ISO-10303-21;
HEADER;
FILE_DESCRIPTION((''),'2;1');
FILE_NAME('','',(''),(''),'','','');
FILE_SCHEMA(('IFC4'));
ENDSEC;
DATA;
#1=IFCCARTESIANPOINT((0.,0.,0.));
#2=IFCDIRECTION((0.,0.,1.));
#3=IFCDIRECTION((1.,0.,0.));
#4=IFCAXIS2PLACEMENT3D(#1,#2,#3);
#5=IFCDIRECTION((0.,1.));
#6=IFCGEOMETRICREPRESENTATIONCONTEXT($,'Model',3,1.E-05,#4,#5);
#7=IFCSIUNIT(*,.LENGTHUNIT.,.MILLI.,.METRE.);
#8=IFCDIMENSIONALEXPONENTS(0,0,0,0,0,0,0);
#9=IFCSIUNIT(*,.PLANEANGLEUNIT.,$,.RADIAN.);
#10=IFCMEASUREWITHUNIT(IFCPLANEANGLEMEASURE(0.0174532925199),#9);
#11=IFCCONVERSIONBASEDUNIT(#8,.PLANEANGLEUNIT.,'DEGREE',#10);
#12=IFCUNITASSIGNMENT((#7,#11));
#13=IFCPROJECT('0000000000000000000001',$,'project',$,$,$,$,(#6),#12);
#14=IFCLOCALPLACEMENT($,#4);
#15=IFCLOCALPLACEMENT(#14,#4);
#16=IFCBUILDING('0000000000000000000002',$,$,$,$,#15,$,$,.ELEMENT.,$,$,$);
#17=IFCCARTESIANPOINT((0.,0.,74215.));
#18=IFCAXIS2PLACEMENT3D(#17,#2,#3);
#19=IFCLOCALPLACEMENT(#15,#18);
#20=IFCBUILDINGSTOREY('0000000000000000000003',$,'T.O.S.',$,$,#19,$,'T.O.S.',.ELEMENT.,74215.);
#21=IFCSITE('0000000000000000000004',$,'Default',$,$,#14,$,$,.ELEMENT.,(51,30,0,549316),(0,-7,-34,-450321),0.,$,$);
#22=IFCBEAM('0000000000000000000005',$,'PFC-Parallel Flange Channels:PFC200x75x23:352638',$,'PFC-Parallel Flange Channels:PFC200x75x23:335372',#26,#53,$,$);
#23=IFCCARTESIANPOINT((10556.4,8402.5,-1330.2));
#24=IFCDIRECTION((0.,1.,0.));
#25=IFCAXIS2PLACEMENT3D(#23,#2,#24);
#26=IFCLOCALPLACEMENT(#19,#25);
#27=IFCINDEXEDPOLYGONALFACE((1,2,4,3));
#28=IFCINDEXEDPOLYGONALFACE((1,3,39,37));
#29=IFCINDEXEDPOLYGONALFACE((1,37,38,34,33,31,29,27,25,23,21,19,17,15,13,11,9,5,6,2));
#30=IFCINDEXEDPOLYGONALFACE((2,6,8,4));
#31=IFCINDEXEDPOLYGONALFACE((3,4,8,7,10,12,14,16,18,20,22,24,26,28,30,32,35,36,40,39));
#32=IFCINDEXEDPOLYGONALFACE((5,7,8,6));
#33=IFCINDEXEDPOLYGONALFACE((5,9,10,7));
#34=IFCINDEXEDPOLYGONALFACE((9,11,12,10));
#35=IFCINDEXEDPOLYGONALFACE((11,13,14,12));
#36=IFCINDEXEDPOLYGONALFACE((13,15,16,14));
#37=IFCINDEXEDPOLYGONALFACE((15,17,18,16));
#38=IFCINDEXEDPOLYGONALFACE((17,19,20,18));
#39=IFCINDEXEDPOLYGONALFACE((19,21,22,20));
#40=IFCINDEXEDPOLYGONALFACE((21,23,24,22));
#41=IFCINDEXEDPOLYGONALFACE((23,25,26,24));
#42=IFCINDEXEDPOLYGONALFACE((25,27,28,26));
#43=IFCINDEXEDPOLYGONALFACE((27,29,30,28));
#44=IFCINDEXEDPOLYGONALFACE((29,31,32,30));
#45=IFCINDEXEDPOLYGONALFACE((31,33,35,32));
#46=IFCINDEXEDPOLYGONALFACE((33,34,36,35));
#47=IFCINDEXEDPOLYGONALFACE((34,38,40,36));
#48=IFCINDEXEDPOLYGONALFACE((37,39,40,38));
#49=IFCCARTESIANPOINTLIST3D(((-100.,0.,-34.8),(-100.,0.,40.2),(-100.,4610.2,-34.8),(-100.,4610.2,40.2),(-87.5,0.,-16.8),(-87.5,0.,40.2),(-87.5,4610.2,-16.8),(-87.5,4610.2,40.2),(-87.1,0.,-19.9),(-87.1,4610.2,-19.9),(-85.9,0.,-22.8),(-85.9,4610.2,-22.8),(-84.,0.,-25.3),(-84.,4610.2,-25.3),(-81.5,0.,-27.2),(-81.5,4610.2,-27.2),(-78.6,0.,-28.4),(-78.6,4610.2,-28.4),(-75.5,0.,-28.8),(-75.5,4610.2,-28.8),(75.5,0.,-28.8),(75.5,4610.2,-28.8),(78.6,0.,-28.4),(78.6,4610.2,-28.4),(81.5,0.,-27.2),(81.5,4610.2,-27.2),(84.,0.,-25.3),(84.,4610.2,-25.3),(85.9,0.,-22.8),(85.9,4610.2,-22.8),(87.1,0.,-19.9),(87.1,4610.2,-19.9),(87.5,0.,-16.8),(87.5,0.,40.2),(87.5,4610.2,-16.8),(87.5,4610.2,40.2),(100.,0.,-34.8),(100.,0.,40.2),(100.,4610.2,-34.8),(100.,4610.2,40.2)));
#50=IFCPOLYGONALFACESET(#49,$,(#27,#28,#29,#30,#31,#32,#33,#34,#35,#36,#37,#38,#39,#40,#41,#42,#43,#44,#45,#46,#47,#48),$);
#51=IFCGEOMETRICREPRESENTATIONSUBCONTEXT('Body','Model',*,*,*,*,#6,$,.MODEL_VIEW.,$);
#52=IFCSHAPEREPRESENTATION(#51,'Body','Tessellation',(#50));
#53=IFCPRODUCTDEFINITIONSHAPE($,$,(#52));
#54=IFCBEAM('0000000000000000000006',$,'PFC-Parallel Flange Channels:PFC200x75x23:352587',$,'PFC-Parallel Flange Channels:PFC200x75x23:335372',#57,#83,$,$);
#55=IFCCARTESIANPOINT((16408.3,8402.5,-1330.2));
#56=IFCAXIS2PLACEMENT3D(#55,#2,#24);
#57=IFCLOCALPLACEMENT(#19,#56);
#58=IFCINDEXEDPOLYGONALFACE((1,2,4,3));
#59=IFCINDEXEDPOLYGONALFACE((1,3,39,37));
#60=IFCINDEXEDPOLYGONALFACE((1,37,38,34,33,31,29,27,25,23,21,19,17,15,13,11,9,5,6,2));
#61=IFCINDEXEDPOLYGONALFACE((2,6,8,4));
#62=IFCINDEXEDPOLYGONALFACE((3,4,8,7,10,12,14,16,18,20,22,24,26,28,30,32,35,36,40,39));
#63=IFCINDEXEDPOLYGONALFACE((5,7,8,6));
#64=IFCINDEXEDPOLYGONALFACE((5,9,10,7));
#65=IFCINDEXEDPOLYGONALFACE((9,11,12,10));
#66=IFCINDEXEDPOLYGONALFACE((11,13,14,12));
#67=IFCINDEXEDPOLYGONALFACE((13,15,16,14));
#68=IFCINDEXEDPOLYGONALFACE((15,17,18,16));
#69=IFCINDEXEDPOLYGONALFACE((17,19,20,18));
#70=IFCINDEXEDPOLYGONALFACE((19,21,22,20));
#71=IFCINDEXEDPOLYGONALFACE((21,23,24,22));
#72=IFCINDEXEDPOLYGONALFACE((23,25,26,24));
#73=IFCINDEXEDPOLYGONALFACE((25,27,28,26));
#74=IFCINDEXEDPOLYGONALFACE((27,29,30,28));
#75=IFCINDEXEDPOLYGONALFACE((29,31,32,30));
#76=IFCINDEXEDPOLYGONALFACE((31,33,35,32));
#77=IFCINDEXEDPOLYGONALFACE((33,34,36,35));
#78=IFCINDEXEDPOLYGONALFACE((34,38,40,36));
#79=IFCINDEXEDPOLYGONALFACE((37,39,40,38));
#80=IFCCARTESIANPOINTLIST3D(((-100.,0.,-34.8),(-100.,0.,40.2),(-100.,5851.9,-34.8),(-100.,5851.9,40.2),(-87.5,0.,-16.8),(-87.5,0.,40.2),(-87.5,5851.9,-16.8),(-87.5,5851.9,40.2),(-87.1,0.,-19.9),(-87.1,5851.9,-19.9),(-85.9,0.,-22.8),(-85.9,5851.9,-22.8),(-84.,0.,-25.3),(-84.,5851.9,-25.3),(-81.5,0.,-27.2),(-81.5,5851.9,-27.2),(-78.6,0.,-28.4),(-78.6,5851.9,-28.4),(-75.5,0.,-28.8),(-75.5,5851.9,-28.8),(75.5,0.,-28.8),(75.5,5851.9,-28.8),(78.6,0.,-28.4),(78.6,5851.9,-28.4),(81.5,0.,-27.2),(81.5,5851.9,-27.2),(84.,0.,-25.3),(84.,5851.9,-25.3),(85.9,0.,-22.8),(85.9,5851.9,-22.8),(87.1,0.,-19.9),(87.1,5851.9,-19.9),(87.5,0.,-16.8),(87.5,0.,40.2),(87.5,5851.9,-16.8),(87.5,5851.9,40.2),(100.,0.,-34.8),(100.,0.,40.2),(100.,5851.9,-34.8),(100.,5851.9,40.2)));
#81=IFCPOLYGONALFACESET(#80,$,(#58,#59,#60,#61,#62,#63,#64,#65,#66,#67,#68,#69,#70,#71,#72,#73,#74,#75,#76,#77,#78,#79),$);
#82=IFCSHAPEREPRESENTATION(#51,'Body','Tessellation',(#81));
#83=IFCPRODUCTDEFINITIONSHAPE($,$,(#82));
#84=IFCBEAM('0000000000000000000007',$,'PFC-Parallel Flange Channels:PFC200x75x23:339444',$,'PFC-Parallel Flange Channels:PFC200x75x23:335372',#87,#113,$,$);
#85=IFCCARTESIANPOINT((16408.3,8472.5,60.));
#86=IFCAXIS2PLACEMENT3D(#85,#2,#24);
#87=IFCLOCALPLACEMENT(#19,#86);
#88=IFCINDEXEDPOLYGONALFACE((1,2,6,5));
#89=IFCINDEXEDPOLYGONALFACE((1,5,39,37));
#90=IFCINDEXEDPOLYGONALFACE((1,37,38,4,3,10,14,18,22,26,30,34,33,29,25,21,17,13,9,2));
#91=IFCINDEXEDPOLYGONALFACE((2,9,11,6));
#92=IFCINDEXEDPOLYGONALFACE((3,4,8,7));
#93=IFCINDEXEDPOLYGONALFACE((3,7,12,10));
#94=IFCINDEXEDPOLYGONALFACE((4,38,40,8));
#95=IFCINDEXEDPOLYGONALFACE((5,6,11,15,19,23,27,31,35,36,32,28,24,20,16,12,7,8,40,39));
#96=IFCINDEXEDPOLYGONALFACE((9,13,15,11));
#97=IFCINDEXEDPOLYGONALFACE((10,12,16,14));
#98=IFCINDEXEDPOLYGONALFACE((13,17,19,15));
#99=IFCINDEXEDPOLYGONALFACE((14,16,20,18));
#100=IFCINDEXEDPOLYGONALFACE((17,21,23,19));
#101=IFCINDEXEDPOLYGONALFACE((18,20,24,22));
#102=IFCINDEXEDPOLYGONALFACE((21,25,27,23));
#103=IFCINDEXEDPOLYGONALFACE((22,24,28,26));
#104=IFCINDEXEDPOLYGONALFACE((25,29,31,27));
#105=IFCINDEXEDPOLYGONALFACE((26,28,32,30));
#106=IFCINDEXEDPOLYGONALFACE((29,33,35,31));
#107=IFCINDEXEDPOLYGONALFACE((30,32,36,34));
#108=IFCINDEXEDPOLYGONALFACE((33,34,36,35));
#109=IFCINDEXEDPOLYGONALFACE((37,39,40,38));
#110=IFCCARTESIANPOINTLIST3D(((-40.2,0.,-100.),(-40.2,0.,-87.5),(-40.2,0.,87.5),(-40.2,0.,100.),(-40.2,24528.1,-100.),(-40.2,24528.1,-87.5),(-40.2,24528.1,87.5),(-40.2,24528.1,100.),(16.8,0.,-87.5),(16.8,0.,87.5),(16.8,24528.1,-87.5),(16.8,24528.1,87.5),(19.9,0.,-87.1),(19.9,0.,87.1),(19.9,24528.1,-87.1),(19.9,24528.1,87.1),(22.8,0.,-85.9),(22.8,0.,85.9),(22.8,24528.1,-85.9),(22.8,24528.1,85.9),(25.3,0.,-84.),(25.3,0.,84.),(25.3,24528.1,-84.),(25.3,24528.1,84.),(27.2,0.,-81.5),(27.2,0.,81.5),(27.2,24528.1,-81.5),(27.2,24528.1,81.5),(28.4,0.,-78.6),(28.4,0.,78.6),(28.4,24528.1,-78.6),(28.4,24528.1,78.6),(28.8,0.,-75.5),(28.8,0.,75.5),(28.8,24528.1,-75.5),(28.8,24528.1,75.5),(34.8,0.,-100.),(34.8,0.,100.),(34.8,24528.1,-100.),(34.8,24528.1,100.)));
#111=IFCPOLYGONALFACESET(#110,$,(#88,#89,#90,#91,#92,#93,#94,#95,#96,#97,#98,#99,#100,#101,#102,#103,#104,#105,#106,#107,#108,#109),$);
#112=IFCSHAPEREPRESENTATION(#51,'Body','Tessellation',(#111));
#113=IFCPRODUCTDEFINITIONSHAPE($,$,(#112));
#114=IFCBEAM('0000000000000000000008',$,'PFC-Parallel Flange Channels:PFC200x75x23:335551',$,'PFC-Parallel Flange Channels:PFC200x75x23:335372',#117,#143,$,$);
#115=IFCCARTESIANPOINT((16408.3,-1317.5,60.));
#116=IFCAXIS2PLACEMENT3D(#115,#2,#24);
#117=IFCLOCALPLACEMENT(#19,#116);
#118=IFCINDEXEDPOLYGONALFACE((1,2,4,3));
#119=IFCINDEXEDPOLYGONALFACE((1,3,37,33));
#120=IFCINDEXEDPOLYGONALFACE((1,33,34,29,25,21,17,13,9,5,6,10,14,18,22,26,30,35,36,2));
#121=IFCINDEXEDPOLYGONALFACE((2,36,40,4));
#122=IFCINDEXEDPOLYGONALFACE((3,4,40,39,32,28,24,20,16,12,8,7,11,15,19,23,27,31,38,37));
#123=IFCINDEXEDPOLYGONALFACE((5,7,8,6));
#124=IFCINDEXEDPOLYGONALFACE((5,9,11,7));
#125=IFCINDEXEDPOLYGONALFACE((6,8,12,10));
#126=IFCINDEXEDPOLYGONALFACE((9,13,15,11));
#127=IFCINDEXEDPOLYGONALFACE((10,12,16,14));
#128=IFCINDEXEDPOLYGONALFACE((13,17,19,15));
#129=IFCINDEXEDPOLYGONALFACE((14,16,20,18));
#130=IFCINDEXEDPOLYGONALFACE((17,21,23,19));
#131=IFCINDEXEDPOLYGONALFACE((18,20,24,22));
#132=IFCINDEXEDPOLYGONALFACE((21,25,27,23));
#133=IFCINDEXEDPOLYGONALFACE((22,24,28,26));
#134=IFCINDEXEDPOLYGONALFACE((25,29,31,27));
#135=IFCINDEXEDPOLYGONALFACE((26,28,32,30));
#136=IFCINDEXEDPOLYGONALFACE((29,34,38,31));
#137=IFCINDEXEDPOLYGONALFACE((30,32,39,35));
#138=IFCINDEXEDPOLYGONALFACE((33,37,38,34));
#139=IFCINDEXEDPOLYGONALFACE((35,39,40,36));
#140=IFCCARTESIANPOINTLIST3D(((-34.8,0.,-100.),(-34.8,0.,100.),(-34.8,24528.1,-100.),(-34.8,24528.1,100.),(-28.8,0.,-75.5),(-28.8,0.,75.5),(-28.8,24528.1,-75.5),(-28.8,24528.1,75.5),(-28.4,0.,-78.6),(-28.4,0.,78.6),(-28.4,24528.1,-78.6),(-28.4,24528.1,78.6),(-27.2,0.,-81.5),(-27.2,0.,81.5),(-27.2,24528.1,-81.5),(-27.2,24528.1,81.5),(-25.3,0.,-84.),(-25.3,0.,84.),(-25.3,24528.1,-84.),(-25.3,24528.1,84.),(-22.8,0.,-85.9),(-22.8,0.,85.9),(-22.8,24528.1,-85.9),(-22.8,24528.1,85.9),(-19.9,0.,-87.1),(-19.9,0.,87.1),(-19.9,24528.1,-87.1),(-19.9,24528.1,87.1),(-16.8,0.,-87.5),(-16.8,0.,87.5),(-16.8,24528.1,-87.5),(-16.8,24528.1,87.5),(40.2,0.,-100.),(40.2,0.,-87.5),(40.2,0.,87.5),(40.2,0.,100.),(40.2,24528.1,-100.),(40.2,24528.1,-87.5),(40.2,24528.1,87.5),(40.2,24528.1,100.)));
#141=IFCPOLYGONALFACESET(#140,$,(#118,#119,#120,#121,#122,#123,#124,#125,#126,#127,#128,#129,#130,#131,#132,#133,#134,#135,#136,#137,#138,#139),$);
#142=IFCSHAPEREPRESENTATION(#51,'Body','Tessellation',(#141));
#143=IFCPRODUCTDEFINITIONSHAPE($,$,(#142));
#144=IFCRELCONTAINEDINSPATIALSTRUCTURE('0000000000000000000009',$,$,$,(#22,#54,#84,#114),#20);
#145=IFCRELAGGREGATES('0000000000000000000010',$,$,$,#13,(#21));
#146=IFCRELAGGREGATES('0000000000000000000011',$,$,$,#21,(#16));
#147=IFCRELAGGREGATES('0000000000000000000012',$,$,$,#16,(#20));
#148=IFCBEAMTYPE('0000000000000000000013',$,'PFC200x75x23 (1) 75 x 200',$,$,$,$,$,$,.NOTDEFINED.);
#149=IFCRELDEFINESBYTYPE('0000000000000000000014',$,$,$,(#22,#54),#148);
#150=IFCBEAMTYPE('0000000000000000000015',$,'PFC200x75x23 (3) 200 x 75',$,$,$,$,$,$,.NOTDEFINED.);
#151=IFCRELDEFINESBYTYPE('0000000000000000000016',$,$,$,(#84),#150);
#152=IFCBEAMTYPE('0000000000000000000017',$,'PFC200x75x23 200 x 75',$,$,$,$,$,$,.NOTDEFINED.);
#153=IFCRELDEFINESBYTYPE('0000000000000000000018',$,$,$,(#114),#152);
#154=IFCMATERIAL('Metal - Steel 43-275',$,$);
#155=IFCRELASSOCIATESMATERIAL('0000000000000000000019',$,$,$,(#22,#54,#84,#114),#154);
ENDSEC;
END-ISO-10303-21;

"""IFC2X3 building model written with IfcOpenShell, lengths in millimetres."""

from ifc_helpers import new_model, entity, si_unit, converted_unit, point, direction, frame, frame_2d, origin_with_axes, place, context, subcontext, project, spatial, polyline, circle_curve, parameter, trimmed, segment, composite_curve, outline, extrude, material, type_object, element, save


model = new_model("IFC2X3")

# Units and contexts
model_context = context("Model", 3, precision=1e-05, world=origin_with_axes(), true_north=direction((0.0, 1.0)))
body_context = subcontext(model_context, "Body", "Model", "MODEL_VIEW")
ifc_project = project(units=[si_unit("LENGTHUNIT", "METRE", prefix="MILLI"), converted_unit("PLANEANGLEUNIT", "DEGREE", entity("IfcPlaneAngleMeasure", 0.0174532925199), si_unit("PLANEANGLEUNIT", "RADIAN"), dimensions=[0, 0, 0, 0, 0, 0, 0])], contexts=[model_context])

# Site, building, storey
site_placement = place(None, origin_with_axes())
site = spatial("IfcSite", under=ifc_project, at=site_placement, Name="Default", CompositionType="ELEMENT", RefLatitude=(51, 30, 0, 549316), RefLongitude=(0, -7, -34, -450321), RefElevation=0.0)
building_placement = place(site_placement, origin_with_axes())
building = spatial("IfcBuilding", under=site, at=building_placement, CompositionType="ELEMENT")
storey_placement = place(building_placement, frame((0.0, 0.0, 74215.0), z_axis=(0.0, 0.0, 1.0), x_axis=(1.0, 0.0, 0.0)))
storey = spatial("IfcBuildingStorey", under=building, at=storey_placement, Name="T.O.S.", LongName="T.O.S.", CompositionType="ELEMENT", Elevation=74215.0)

# Beams
ifc_material = material(Name="Metal - Steel 43-275")
beam_type_1 = type_object("IfcBeamType", Name="PFC200x75x23 (1) 75 x 200", PredefinedType="NOTDEFINED")
beam_1_placement = place(storey_placement, frame((10556.4, 8402.5, -1330.2), z_axis=(0.0, 0.0, 1.0), x_axis=(0.0, 1.0, 0.0)))
element("IfcBeam", 1, at=beam_1_placement, inside=storey, type_object=beam_type_1, material=ifc_material, Name="PFC-Parallel Flange Channels:PFC200x75x23:352638", ObjectType="PFC-Parallel Flange Channels:PFC200x75x23:335372", context=body_context, shape_type="SweptSolid", body=[
    extrude(outline(composite_curve([segment(polyline([(-40.2, -100.0), (34.8, -100.0), (34.8, 100.0), (-40.2, 100.0), (-40.2, 87.5), (16.8, 87.5)]), True, "CONTINUOUS"), segment(trimmed(circle_curve(frame_2d((16.8, 75.5), x_axis=(1.0, 0.0)), 12.0), [point((16.8, 87.5)), parameter(90.0)], [point((28.8, 75.5)), parameter(0.0)], False, "CARTESIAN"), True, "CONTINUOUS"), segment(polyline([(28.8, 75.5), (28.8, -75.5)]), True, "CONTINUOUS"), segment(trimmed(circle_curve(frame_2d((16.8, -75.5), x_axis=(0.0, -1.0)), 12.0), [point((28.8, -75.5)), parameter(90.0)], [point((16.8, -87.5)), parameter(0.0)], False, "CARTESIAN"), True, "CONTINUOUS"), segment(polyline([(16.8, -87.5), (-40.2, -87.5), (-40.2, -100.0)]), True, "CONTINUOUS")], self_intersect=False)), frame((0.0, 4610.2, 0.0), z_axis=(0.0, -1.0, 0.0), x_axis=(0.0, 0.0, -1.0)), (0.0, 0.0, 1.0), 4610.2),
])
beam_2_placement = place(storey_placement, frame((16408.3, 8402.5, -1330.2), z_axis=(0.0, 0.0, 1.0), x_axis=(0.0, 1.0, 0.0)))
element("IfcBeam", 2, at=beam_2_placement, inside=storey, type_object=beam_type_1, material=ifc_material, Name="PFC-Parallel Flange Channels:PFC200x75x23:352587", ObjectType="PFC-Parallel Flange Channels:PFC200x75x23:335372", context=body_context, shape_type="SweptSolid", body=[
    extrude(outline(composite_curve([segment(polyline([(-40.2, -100.0), (34.8, -100.0), (34.8, 100.0), (-40.2, 100.0), (-40.2, 87.5), (16.8, 87.5)]), True, "CONTINUOUS"), segment(trimmed(circle_curve(frame_2d((16.8, 75.5), x_axis=(1.0, 0.0)), 12.0), [point((16.8, 87.5)), parameter(90.0)], [point((28.8, 75.5)), parameter(0.0)], False, "CARTESIAN"), True, "CONTINUOUS"), segment(polyline([(28.8, 75.5), (28.8, -75.5)]), True, "CONTINUOUS"), segment(trimmed(circle_curve(frame_2d((16.8, -75.5), x_axis=(0.0, -1.0)), 12.0), [point((28.8, -75.5)), parameter(90.0)], [point((16.8, -87.5)), parameter(0.0)], False, "CARTESIAN"), True, "CONTINUOUS"), segment(polyline([(16.8, -87.5), (-40.2, -87.5), (-40.2, -100.0)]), True, "CONTINUOUS")], self_intersect=False)), frame((0.0, 5851.9, 0.0), z_axis=(0.0, -1.0, 0.0), x_axis=(0.0, 0.0, -1.0)), (0.0, 0.0, 1.0), 5851.9),
])
beam_type_2 = type_object("IfcBeamType", Name="PFC200x75x23 (3) 200 x 75", PredefinedType="NOTDEFINED")
beam_3_placement = place(storey_placement, frame((16408.3, 8472.5, 60.0), z_axis=(0.0, 0.0, 1.0), x_axis=(0.0, 1.0, 0.0)))
element("IfcBeam", 3, at=beam_3_placement, inside=storey, type_object=beam_type_2, material=ifc_material, Name="PFC-Parallel Flange Channels:PFC200x75x23:339444", ObjectType="PFC-Parallel Flange Channels:PFC200x75x23:335372", context=body_context, shape_type="SweptSolid", body=[
    extrude(outline(composite_curve([segment(polyline([(-100.0, -40.2), (-87.5, -40.2), (-87.5, 16.8)]), True, "CONTINUOUS"), segment(trimmed(circle_curve(frame_2d((-75.5, 16.8), x_axis=(0.0, 1.0)), 12.0), [point((-87.5, 16.8)), parameter(90.0)], [point((-75.5, 28.8)), parameter(0.0)], False, "CARTESIAN"), True, "CONTINUOUS"), segment(polyline([(-75.5, 28.8), (75.5, 28.8)]), True, "CONTINUOUS"), segment(trimmed(circle_curve(frame_2d((75.5, 16.8), x_axis=(1.0, 0.0)), 12.0), [point((75.5, 28.8)), parameter(90.0)], [point((87.5, 16.8)), parameter(0.0)], False, "CARTESIAN"), True, "CONTINUOUS"), segment(polyline([(87.5, 16.8), (87.5, -40.2), (100.0, -40.2), (100.0, 34.8), (-100.0, 34.8), (-100.0, -40.2)]), True, "CONTINUOUS")], self_intersect=False)), frame((0.0, 24528.1, 0.0), z_axis=(0.0, -1.0, 0.0), x_axis=(0.0, 0.0, -1.0)), (0.0, 0.0, 1.0), 24528.1),
])
beam_type_3 = type_object("IfcBeamType", Name="PFC200x75x23 200 x 75", PredefinedType="NOTDEFINED")
beam_4_placement = place(storey_placement, frame((16408.3, -1317.5, 60.0), z_axis=(0.0, 0.0, 1.0), x_axis=(0.0, 1.0, 0.0)))
element("IfcBeam", 4, at=beam_4_placement, inside=storey, type_object=beam_type_3, material=ifc_material, Name="PFC-Parallel Flange Channels:PFC200x75x23:335551", ObjectType="PFC-Parallel Flange Channels:PFC200x75x23:335372", context=body_context, shape_type="SweptSolid", body=[
    extrude(outline(composite_curve([segment(polyline([(-100.0, -34.8), (100.0, -34.8), (100.0, 40.2), (87.5, 40.2), (87.5, -16.8)]), True, "CONTINUOUS"), segment(trimmed(circle_curve(frame_2d((75.5, -16.8), x_axis=(0.0, -1.0)), 12.0), [point((87.5, -16.8)), parameter(90.0)], [point((75.5, -28.8)), parameter(0.0)], False, "CARTESIAN"), True, "CONTINUOUS"), segment(polyline([(75.5, -28.8), (-75.5, -28.8)]), True, "CONTINUOUS"), segment(trimmed(circle_curve(frame_2d((-75.5, -16.8), x_axis=(-1.0, 0.0)), 12.0), [point((-75.5, -28.8)), parameter(90.0)], [point((-87.5, -16.8)), parameter(0.0)], False, "CARTESIAN"), True, "CONTINUOUS"), segment(polyline([(-87.5, -16.8), (-87.5, 40.2), (-100.0, 40.2), (-100.0, -34.8)]), True, "CONTINUOUS")], self_intersect=False)), frame((0.0, 24528.1, 0.0), z_axis=(0.0, -1.0, 0.0), x_axis=(0.0, 0.0, -1.0)), (0.0, 0.0, 1.0), 24528.1),
])

save(model, "model.ifc")
